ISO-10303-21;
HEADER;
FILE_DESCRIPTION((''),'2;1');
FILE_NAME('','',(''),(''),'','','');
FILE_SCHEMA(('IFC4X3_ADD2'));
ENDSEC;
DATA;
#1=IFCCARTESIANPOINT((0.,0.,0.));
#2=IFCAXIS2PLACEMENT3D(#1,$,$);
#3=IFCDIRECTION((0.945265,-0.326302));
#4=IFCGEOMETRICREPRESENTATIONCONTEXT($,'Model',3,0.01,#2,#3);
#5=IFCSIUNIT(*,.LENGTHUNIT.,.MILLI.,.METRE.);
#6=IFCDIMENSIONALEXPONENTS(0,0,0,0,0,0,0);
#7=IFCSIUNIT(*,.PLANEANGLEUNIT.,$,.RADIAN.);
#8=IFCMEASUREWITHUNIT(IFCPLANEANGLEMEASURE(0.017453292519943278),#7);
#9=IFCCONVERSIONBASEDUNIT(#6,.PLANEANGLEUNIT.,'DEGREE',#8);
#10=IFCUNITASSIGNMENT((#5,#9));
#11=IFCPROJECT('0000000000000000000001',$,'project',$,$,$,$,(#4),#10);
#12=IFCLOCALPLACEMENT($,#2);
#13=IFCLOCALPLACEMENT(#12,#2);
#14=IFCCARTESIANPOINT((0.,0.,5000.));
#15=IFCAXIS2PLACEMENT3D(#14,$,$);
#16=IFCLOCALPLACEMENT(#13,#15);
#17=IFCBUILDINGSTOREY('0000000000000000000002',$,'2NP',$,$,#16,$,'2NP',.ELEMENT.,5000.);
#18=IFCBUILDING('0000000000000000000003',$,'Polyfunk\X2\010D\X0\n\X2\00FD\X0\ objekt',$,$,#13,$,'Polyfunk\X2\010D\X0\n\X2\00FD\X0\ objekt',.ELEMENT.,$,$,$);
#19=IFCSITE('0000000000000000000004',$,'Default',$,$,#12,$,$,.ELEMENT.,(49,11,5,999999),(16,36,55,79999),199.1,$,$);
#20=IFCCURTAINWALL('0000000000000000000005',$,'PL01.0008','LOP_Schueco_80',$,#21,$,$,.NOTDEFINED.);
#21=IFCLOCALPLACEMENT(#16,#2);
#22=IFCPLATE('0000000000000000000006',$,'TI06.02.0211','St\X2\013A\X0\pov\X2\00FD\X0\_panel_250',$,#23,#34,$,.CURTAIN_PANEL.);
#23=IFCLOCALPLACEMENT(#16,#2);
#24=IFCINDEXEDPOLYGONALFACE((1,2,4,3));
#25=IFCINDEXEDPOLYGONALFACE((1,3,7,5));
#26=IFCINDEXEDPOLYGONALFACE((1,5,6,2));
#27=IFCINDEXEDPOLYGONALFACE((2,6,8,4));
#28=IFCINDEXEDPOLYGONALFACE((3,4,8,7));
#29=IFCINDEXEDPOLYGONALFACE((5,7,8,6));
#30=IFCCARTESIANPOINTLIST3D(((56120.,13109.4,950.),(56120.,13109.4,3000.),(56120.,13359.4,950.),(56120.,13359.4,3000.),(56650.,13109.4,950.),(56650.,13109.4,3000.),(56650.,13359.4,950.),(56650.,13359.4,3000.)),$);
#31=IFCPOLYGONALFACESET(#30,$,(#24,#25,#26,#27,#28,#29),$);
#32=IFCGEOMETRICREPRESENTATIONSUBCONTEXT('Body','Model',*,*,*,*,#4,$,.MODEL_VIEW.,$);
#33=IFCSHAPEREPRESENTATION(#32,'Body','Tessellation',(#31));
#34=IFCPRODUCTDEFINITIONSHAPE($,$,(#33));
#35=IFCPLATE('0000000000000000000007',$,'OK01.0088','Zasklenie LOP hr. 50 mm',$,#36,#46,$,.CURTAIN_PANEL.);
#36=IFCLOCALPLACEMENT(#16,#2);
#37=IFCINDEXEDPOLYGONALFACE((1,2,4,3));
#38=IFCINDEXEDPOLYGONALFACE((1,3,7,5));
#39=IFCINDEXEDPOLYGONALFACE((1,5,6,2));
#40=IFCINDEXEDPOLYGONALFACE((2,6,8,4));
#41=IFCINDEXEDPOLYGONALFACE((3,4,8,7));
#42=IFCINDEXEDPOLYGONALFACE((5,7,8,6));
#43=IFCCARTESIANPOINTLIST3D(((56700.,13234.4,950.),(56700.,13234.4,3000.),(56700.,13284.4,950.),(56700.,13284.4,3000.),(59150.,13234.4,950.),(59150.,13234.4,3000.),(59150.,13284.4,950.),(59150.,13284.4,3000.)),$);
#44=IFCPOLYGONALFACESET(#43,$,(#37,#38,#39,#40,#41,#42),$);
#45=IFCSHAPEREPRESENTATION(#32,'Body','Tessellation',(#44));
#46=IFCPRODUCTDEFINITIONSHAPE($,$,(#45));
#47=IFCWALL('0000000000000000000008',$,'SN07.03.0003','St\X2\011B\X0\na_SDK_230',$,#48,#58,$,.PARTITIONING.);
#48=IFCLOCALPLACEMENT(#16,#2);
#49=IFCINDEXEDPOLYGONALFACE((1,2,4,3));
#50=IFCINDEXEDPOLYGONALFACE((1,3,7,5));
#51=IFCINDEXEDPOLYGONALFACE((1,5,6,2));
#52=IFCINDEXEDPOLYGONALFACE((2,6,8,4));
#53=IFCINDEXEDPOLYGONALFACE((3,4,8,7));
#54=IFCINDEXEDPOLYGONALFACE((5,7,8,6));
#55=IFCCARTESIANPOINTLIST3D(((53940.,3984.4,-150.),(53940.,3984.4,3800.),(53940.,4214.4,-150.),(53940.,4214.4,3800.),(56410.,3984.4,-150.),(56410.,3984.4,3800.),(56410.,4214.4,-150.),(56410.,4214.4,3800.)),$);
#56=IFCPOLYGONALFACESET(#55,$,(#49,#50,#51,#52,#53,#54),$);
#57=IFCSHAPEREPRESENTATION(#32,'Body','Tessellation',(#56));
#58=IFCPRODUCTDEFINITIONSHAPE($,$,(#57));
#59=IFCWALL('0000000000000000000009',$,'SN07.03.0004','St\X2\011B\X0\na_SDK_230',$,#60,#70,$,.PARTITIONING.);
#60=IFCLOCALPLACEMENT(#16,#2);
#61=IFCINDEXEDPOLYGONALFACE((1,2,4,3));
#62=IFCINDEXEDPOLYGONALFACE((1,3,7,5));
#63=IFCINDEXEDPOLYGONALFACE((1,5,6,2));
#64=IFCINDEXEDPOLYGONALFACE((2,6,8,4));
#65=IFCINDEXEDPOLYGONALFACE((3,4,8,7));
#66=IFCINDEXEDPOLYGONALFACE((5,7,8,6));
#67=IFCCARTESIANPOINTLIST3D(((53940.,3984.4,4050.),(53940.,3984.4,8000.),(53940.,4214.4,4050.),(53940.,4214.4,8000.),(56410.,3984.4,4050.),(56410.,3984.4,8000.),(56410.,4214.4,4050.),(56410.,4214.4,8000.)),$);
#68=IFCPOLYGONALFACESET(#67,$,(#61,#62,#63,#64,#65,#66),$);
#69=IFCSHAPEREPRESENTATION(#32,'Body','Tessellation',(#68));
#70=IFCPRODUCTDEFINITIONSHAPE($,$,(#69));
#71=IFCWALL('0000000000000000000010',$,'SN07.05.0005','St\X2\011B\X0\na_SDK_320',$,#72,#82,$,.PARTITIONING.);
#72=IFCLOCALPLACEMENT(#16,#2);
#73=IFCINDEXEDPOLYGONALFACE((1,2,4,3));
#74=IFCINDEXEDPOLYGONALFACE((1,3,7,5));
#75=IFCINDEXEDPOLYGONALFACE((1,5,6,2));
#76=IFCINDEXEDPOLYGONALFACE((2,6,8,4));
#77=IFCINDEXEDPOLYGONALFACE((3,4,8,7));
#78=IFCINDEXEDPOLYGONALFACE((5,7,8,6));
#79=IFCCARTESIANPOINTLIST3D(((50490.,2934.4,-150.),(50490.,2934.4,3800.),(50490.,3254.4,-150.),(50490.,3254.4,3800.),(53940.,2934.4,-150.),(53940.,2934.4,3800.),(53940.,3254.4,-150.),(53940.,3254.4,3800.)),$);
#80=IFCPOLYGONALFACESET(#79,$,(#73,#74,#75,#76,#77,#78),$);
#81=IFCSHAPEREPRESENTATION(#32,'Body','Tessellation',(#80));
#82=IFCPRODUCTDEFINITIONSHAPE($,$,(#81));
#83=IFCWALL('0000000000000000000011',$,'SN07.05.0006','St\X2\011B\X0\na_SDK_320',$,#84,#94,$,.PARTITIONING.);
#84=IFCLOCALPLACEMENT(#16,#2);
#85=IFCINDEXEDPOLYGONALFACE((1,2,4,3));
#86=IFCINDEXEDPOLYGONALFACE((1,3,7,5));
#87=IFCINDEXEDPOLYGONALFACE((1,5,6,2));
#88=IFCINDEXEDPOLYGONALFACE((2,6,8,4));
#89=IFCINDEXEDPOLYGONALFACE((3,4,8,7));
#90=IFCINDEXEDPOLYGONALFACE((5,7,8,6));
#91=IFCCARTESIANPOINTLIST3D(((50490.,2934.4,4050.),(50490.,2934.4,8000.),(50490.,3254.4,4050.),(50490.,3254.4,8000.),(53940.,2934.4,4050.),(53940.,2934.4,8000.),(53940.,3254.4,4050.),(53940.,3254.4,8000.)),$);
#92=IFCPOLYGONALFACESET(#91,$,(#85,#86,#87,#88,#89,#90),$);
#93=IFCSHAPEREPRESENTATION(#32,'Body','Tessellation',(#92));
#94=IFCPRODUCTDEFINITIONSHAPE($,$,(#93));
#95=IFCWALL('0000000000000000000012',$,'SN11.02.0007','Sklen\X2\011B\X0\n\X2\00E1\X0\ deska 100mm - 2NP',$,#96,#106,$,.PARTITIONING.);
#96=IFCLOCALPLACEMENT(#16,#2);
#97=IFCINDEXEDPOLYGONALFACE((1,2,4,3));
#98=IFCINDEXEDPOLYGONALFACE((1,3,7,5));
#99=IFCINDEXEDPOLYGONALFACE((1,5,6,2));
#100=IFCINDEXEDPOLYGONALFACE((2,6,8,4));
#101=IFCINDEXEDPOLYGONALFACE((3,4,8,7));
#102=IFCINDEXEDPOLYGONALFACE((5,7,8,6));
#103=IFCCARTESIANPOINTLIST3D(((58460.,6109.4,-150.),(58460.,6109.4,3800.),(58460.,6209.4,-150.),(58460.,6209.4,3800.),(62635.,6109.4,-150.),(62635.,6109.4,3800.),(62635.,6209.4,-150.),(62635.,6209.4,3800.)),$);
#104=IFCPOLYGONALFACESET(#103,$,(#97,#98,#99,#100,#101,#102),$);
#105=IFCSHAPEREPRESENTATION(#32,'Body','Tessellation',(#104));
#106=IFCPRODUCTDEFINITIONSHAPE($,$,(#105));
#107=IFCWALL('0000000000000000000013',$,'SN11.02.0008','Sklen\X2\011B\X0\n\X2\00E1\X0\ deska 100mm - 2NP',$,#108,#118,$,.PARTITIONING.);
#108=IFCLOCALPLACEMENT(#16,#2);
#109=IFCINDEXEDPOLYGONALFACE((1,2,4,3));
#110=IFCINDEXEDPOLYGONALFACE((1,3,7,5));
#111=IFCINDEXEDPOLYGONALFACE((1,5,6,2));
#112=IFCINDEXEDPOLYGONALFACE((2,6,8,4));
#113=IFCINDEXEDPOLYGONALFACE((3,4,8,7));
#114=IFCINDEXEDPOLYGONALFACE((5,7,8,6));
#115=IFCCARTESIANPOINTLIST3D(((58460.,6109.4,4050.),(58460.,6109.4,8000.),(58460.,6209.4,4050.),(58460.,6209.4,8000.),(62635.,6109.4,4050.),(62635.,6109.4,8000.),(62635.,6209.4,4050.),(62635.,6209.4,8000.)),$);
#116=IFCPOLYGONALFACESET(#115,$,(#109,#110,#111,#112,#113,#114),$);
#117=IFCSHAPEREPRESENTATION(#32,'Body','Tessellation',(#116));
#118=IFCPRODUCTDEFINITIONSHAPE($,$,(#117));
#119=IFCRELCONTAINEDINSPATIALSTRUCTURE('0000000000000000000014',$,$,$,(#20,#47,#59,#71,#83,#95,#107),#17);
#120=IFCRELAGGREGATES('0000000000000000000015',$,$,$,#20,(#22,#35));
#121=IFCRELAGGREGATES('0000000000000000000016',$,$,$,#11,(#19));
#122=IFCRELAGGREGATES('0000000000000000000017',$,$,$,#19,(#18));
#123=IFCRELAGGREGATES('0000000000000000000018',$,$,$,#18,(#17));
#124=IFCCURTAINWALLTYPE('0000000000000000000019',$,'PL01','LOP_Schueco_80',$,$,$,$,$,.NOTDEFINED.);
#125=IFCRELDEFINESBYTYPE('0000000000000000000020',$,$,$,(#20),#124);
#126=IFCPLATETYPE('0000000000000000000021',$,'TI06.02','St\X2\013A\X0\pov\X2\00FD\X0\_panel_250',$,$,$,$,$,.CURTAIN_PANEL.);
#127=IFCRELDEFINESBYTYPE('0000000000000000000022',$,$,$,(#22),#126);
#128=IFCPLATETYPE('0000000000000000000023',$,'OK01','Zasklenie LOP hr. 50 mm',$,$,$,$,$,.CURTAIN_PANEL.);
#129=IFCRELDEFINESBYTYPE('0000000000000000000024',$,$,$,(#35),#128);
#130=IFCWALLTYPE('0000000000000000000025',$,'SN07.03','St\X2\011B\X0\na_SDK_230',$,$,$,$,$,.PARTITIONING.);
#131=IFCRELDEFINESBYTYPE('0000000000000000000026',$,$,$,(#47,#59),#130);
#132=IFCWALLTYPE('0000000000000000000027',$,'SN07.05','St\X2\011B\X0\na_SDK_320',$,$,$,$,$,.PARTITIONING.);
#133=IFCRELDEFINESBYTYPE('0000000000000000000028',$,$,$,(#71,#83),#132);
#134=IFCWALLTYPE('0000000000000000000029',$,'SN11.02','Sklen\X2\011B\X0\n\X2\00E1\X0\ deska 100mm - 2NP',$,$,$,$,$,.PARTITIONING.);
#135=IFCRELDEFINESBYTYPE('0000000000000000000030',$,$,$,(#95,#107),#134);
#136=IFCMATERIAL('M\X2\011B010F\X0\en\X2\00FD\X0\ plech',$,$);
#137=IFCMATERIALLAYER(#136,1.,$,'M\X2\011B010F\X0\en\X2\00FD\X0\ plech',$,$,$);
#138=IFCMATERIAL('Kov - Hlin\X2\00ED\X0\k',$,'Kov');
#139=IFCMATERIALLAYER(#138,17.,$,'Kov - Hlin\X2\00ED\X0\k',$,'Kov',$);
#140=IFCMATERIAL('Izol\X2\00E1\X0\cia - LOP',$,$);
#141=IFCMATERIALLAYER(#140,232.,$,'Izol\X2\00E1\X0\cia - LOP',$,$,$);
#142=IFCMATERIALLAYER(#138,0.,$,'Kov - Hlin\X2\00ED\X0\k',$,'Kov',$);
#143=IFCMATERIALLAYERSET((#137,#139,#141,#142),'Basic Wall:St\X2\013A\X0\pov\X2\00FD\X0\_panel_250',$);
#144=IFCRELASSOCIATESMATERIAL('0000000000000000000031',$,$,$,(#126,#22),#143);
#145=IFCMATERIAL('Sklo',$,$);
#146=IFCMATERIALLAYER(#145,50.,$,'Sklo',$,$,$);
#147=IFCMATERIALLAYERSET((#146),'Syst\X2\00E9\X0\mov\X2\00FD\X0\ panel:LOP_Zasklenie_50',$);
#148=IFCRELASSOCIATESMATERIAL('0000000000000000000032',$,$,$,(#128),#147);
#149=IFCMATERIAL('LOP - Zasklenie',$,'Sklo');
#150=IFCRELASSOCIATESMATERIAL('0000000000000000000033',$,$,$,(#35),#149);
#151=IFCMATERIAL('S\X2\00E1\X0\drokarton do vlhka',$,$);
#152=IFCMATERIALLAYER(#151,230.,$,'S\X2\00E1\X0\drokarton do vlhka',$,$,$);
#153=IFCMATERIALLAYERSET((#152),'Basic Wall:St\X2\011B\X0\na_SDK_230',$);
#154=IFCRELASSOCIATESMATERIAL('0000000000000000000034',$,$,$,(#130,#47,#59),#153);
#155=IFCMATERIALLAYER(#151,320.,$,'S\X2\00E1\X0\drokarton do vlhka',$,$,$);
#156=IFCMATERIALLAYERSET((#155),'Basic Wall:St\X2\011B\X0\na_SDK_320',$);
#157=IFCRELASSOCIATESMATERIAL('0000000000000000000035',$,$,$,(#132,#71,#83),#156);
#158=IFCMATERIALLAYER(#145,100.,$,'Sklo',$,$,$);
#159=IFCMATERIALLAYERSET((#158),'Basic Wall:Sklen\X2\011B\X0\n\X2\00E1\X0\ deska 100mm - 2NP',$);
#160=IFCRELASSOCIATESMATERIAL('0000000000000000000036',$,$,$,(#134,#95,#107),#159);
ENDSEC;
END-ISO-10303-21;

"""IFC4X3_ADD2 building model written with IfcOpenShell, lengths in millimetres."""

from ifc_helpers import new_model, entity, si_unit, converted_unit, direction, frame, frame_2d, origin, origin_2d_with_axis, place, context, subcontext, project, spatial, polyline, rectangle, extrude, clip, bounded_halfspace, source, transform, mapped, material, layer, layer_set, layer_usage, type_object, type_shapes, element, aggregate, save


model = new_model("IFC4X3_ADD2")

# Units and contexts
model_context = context("Model", 3, precision=0.01, world=origin(), true_north=direction((0.945265, -0.326302)))
body_context = subcontext(model_context, "Body", "Model", "MODEL_VIEW")
ifc_project = project(units=[si_unit("LENGTHUNIT", "METRE", prefix="MILLI"), converted_unit("PLANEANGLEUNIT", "DEGREE", entity("IfcPlaneAngleMeasure", 0.017453292519943278), si_unit("PLANEANGLEUNIT", "RADIAN"), dimensions=[0, 0, 0, 0, 0, 0, 0])], contexts=[model_context])

# Site, building, storey
site_placement = place(None, origin())
site = spatial("IfcSite", under=ifc_project, at=site_placement, Name="Default", CompositionType="ELEMENT", RefLatitude=(49, 11, 5, 999999), RefLongitude=(16, 36, 55, 79999), RefElevation=199.1)
building_placement = place(site_placement, origin())
building = spatial("IfcBuilding", under=site, at=building_placement, Name="Polyfunkčný objekt", LongName="Polyfunkčný objekt", CompositionType="ELEMENT")
storey_placement = place(building_placement, frame((0.0, 0.0, 5000.0)))
storey = spatial("IfcBuildingStorey", under=building, at=storey_placement, Name="2NP", LongName="2NP", CompositionType="ELEMENT", Elevation=5000.0)

# Curtain wall, plates
curtain_wall_type = type_object("IfcCurtainWallType", Name="PL01", Description="LOP_Schueco_80", PredefinedType="NOTDEFINED")
curtain_wall_placement = place(storey_placement, frame((0.0, 0.0, -5000.0)))
curtain_wall = element("IfcCurtainWall", 1, at=curtain_wall_placement, inside=storey, type_object=curtain_wall_type, Name="PL01.0008", Description="LOP_Schueco_80", PredefinedType="NOTDEFINED")
ifc_material_1 = material(Name="Měďený plech")
ifc_layer_1 = layer(ifc_material_1, 1.0, Name="Měďený plech")
ifc_material_2 = material(Name="Kov - Hliník", Category="Kov")
ifc_layer_2 = layer(ifc_material_2, 17.0, Name="Kov - Hliník", Category="Kov")
ifc_material_3 = material(Name="Izolácia - LOP")
ifc_layer_3 = layer(ifc_material_3, 232.0, Name="Izolácia - LOP")
ifc_layer_4 = layer(ifc_material_2, 0.0, Name="Kov - Hliník", Category="Kov")
ifc_layer_set_1 = layer_set([ifc_layer_1, ifc_layer_2, ifc_layer_3, ifc_layer_4], Name="Basic Wall:Stĺpový_panel_250")
ifc_layer_usage = layer_usage(ifc_layer_set_1, "AXIS2", "NEGATIVE", 125.0)
plate_type_1 = type_object("IfcPlateType", Name="TI06.02", Description="Stĺpový_panel_250", PredefinedType="CURTAIN_PANEL", material=ifc_layer_set_1)
plate_1_placement = place(storey_placement, frame((56120.0, 13234.4, 950.0)))
plate_1 = element("IfcPlate", 2, at=plate_1_placement, type_object=plate_type_1, material=ifc_layer_usage, Name="TI06.02.0211", Description="Stĺpový_panel_250", PredefinedType="CURTAIN_PANEL", context=body_context, shape_type="SweptSolid", body=[
    extrude(rectangle(XDim=250.0, YDim=530.0, at=frame_2d((0.0, 0.0), x_axis=(1.0, 0.0))), frame((265.0, 0.0, 0.0), z_axis=(0.0, 0.0, 1.0), x_axis=(0.0, 1.0, 0.0)), (0.0, 0.0, 1.0), 2050.0),
])
ifc_material_4 = material(Name="LOP - Zasklenie", Category="Sklo")
ifc_material_5 = material(Name="Sklo")
ifc_layer_5 = layer(ifc_material_5, 50.0, Name="Sklo")
ifc_layer_set_2 = layer_set([ifc_layer_5], Name="Systémový panel:LOP_Zasklenie_50")
plate_type_2 = type_object("IfcPlateType", Name="OK01", Description="Zasklenie LOP hr. 50 mm", PredefinedType="CURTAIN_PANEL", material=ifc_layer_set_2)
shared_shape_1 = source(origin(), body_context, "Body", "SweptSolid", [
    extrude(rectangle(XDim=50.0, YDim=2450.0, at=origin_2d_with_axis()), frame((0.0, 25.0, 0.0), z_axis=(0.0, 0.0, 1.0), x_axis=(0.0, 1.0, 0.0)), (0.0, 0.0, 1.0), 2050.0),
])
type_shapes(plate_type_2, [shared_shape_1])
plate_2_placement = place(curtain_wall_placement, frame((57925.0, 13234.4, 5950.0)))
plate_2 = element("IfcPlate", 3, at=plate_2_placement, type_object=plate_type_2, material=ifc_material_4, Name="OK01.0088", Description="Zasklenie LOP hr. 50 mm", PredefinedType="CURTAIN_PANEL", context=body_context, shape_type="MappedRepresentation", body=[
    mapped(shared_shape_1, transform((0.0, 0.0, 0.0), scale=1.0)),
])
aggregate(curtain_wall, [plate_1, plate_2])

# Walls
ifc_material_6 = material(Name="Sádrokarton do vlhka")
ifc_layer_6 = layer(ifc_material_6, 230.0, Name="Sádrokarton do vlhka")
ifc_layer_set_3 = layer_set([ifc_layer_6], Name="Basic Wall:Stěna_SDK_230")
wall_type_1 = type_object("IfcWallType", Name="SN07.03", Description="Stěna_SDK_230", PredefinedType="PARTITIONING", material=ifc_layer_set_3)
wall_1_placement = place(storey_placement, frame((56410.0, 4099.4, -150.0), z_axis=(0.0, 0.0, 1.0), x_axis=(-1.0, 0.0, 0.0)))
element("IfcWall", 4, at=wall_1_placement, inside=storey, type_object=wall_type_1, material=ifc_layer_set_3, Name="SN07.03.0003", Description="Stěna_SDK_230", PredefinedType="PARTITIONING", context=body_context, shape_type="Clipping", body=[
    clip(clip(extrude(rectangle(XDim=2470.0, YDim=230.0, at=frame_2d((1235.0, 0.0), x_axis=(-1.0, 0.0))), origin(), (0.0, 0.0, 1.0), 3950.0), bounded_halfspace(frame((2470.0, -115.0, 0.0)), True, frame((2470.0, -115.0, 0.0)), polyline([(0.0, 0.0), (0.0, 60.0), (0.0, 230.0), (-320.0, 230.0), (-2470.0, 230.0), (-2470.0, 0.0), (-150.0, 0.0), (0.0, 0.0)]))), bounded_halfspace(frame((0.0, -115.0, 3950.0), z_axis=(0.0, 0.0, -1.0), x_axis=(-1.0, 0.0, 0.0)), True, frame((0.0, -115.0, 3950.0)), polyline([(0.0, 0.0), (2320.0, 0.0), (2470.0, 0.0), (2470.0, 60.0), (2470.0, 230.0), (2150.0, 230.0), (0.0, 230.0), (0.0, 0.0)]))),
])
wall_2_placement = place(storey_placement, frame((56410.0, 4099.4, 4050.0), z_axis=(0.0, 0.0, 1.0), x_axis=(-1.0, 0.0, 0.0)))
element("IfcWall", 5, at=wall_2_placement, inside=storey, type_object=wall_type_1, material=ifc_layer_set_3, Name="SN07.03.0004", Description="Stěna_SDK_230", PredefinedType="PARTITIONING", context=body_context, shape_type="Clipping", body=[
    clip(clip(extrude(rectangle(XDim=2470.0, YDim=230.0, at=frame_2d((1235.0, 0.0), x_axis=(-1.0, 0.0))), origin(), (0.0, 0.0, 1.0), 3950.0), bounded_halfspace(frame((2470.0, -115.0, 0.0)), True, frame((2470.0, -115.0, 0.0)), polyline([(0.0, 0.0), (0.0, 60.0), (0.0, 230.0), (-320.0, 230.0), (-2470.0, 230.0), (-2470.0, 0.0), (-150.0, 0.0), (0.0, 0.0)]))), bounded_halfspace(frame((0.0, -115.0, 3950.0), z_axis=(0.0, 0.0, -1.0), x_axis=(-1.0, 0.0, 0.0)), True, frame((0.0, -115.0, 3950.0)), polyline([(0.0, 0.0), (2320.0, 0.0), (2470.0, 0.0), (2470.0, 60.0), (2470.0, 230.0), (2150.0, 230.0), (0.0, 230.0), (0.0, 0.0)]))),
])
ifc_layer_7 = layer(ifc_material_6, 320.0, Name="Sádrokarton do vlhka")
ifc_layer_set_4 = layer_set([ifc_layer_7], Name="Basic Wall:Stěna_SDK_320")
wall_type_2 = type_object("IfcWallType", Name="SN07.05", Description="Stěna_SDK_320", PredefinedType="PARTITIONING", material=ifc_layer_set_4)
wall_3_placement = place(storey_placement, frame((53940.0, 3094.4, -150.0), z_axis=(0.0, 0.0, 1.0), x_axis=(-1.0, 0.0, 0.0)))
element("IfcWall", 6, at=wall_3_placement, inside=storey, type_object=wall_type_2, material=ifc_layer_set_4, Name="SN07.05.0005", Description="Stěna_SDK_320", PredefinedType="PARTITIONING", context=body_context, shape_type="Clipping", body=[
    clip(clip(extrude(rectangle(XDim=3450.0, YDim=320.0, at=frame_2d((1725.0, 0.0), x_axis=(-1.0, 0.0))), origin(), (0.0, 0.0, 1.0), 3950.0), bounded_halfspace(frame((3450.0, -160.0, 0.0)), True, frame((3450.0, -160.0, 0.0)), polyline([(0.0, 0.0), (0.0, 320.0), (-1650.0, 320.0), (-1800.0, 320.0), (-3450.0, 320.0), (-3450.0, 0.0), (-1800.0, 0.0), (-1650.0, 0.0), (0.0, 0.0)]))), bounded_halfspace(frame((0.0, -160.0, 3950.0), z_axis=(0.0, 0.0, -1.0), x_axis=(-1.0, 0.0, 0.0)), True, frame((0.0, -160.0, 3950.0)), polyline([(0.0, 0.0), (1650.0, 0.0), (1800.0, 0.0), (3450.0, 0.0), (3450.0, 320.0), (1800.0, 320.0), (1650.0, 320.0), (0.0, 320.0), (0.0, 0.0)]))),
])
wall_4_placement = place(storey_placement, frame((53940.0, 3094.4, 4050.0), z_axis=(0.0, 0.0, 1.0), x_axis=(-1.0, 0.0, 0.0)))
element("IfcWall", 7, at=wall_4_placement, inside=storey, type_object=wall_type_2, material=ifc_layer_set_4, Name="SN07.05.0006", Description="Stěna_SDK_320", PredefinedType="PARTITIONING", context=body_context, shape_type="Clipping", body=[
    clip(clip(extrude(rectangle(XDim=3450.0, YDim=320.0, at=frame_2d((1725.0, 0.0), x_axis=(-1.0, 0.0))), origin(), (0.0, 0.0, 1.0), 3950.0), bounded_halfspace(frame((3450.0, -160.0, 0.0)), True, frame((3450.0, -160.0, 0.0)), polyline([(0.0, 0.0), (0.0, 320.0), (-1650.0, 320.0), (-1800.0, 320.0), (-3450.0, 320.0), (-3450.0, 0.0), (-1800.0, 0.0), (-1650.0, 0.0), (0.0, 0.0)]))), bounded_halfspace(frame((0.0, -160.0, 3950.0), z_axis=(0.0, 0.0, -1.0), x_axis=(-1.0, 0.0, 0.0)), True, frame((0.0, -160.0, 3950.0)), polyline([(0.0, 0.0), (1650.0, 0.0), (1800.0, 0.0), (3450.0, 0.0), (3450.0, 320.0), (1800.0, 320.0), (1650.0, 320.0), (0.0, 320.0), (0.0, 0.0)]))),
])
ifc_layer_8 = layer(ifc_material_5, 100.0, Name="Sklo")
ifc_layer_set_5 = layer_set([ifc_layer_8], Name="Basic Wall:Skleněná deska 100mm - 2NP")
wall_type_3 = type_object("IfcWallType", Name="SN11.02", Description="Skleněná deska 100mm - 2NP", PredefinedType="PARTITIONING", material=ifc_layer_set_5)
wall_5_placement = place(storey_placement, frame((58460.0, 6159.4, -150.0)))
element("IfcWall", 8, at=wall_5_placement, inside=storey, type_object=wall_type_3, material=ifc_layer_set_5, Name="SN11.02.0007", Description="Skleněná deska 100mm - 2NP", PredefinedType="PARTITIONING", context=body_context, shape_type="Clipping", body=[
    clip(clip(extrude(rectangle(XDim=4175.0, YDim=100.0, at=frame_2d((2087.5, 0.0), x_axis=(-1.0, 0.0))), origin(), (0.0, 0.0, 1.0), 3950.0), bounded_halfspace(frame((4175.0, -50.0, 0.0), z_axis=(0.0, 0.0, 1.0), x_axis=(-1.0, 0.0, 0.0)), True, frame((4175.0, -50.0, 0.0)), polyline([(0.0, 0.0), (0.0, 100.0), (-4175.0, 100.0), (-4175.0, 0.0), (-4075.0, 0.0), (0.0, 0.0)]))), bounded_halfspace(frame((0.0, -50.0, 3950.0), z_axis=(0.0, 0.0, -1.0), x_axis=(1.0, 0.0, 0.0)), True, frame((0.0, -50.0, 3950.0)), polyline([(0.0, 0.0), (100.0, 0.0), (4175.0, 0.0), (4175.0, 100.0), (0.0, 100.0), (0.0, 0.0)]))),
])
wall_6_placement = place(storey_placement, frame((58460.0, 6159.4, 4050.0)))
element("IfcWall", 9, at=wall_6_placement, inside=storey, type_object=wall_type_3, material=ifc_layer_set_5, Name="SN11.02.0008", Description="Skleněná deska 100mm - 2NP", PredefinedType="PARTITIONING", context=body_context, shape_type="Clipping", body=[
    clip(clip(extrude(rectangle(XDim=4175.0, YDim=100.0, at=frame_2d((2087.5, 0.0), x_axis=(-1.0, 0.0))), origin(), (0.0, 0.0, 1.0), 3950.0), bounded_halfspace(frame((4175.0, -50.0, 0.0), z_axis=(0.0, 0.0, 1.0), x_axis=(-1.0, 0.0, 0.0)), True, frame((4175.0, -50.0, 0.0)), polyline([(0.0, 0.0), (0.0, 100.0), (-4175.0, 100.0), (-4175.0, 0.0), (-4075.0, 0.0), (0.0, 0.0)]))), bounded_halfspace(frame((0.0, -50.0, 3950.0), z_axis=(0.0, 0.0, -1.0), x_axis=(1.0, 0.0, 0.0)), True, frame((0.0, -50.0, 3950.0)), polyline([(0.0, 0.0), (100.0, 0.0), (4175.0, 0.0), (4175.0, 100.0), (0.0, 100.0), (0.0, 0.0)]))),
])

save(model, "model.ifc")
